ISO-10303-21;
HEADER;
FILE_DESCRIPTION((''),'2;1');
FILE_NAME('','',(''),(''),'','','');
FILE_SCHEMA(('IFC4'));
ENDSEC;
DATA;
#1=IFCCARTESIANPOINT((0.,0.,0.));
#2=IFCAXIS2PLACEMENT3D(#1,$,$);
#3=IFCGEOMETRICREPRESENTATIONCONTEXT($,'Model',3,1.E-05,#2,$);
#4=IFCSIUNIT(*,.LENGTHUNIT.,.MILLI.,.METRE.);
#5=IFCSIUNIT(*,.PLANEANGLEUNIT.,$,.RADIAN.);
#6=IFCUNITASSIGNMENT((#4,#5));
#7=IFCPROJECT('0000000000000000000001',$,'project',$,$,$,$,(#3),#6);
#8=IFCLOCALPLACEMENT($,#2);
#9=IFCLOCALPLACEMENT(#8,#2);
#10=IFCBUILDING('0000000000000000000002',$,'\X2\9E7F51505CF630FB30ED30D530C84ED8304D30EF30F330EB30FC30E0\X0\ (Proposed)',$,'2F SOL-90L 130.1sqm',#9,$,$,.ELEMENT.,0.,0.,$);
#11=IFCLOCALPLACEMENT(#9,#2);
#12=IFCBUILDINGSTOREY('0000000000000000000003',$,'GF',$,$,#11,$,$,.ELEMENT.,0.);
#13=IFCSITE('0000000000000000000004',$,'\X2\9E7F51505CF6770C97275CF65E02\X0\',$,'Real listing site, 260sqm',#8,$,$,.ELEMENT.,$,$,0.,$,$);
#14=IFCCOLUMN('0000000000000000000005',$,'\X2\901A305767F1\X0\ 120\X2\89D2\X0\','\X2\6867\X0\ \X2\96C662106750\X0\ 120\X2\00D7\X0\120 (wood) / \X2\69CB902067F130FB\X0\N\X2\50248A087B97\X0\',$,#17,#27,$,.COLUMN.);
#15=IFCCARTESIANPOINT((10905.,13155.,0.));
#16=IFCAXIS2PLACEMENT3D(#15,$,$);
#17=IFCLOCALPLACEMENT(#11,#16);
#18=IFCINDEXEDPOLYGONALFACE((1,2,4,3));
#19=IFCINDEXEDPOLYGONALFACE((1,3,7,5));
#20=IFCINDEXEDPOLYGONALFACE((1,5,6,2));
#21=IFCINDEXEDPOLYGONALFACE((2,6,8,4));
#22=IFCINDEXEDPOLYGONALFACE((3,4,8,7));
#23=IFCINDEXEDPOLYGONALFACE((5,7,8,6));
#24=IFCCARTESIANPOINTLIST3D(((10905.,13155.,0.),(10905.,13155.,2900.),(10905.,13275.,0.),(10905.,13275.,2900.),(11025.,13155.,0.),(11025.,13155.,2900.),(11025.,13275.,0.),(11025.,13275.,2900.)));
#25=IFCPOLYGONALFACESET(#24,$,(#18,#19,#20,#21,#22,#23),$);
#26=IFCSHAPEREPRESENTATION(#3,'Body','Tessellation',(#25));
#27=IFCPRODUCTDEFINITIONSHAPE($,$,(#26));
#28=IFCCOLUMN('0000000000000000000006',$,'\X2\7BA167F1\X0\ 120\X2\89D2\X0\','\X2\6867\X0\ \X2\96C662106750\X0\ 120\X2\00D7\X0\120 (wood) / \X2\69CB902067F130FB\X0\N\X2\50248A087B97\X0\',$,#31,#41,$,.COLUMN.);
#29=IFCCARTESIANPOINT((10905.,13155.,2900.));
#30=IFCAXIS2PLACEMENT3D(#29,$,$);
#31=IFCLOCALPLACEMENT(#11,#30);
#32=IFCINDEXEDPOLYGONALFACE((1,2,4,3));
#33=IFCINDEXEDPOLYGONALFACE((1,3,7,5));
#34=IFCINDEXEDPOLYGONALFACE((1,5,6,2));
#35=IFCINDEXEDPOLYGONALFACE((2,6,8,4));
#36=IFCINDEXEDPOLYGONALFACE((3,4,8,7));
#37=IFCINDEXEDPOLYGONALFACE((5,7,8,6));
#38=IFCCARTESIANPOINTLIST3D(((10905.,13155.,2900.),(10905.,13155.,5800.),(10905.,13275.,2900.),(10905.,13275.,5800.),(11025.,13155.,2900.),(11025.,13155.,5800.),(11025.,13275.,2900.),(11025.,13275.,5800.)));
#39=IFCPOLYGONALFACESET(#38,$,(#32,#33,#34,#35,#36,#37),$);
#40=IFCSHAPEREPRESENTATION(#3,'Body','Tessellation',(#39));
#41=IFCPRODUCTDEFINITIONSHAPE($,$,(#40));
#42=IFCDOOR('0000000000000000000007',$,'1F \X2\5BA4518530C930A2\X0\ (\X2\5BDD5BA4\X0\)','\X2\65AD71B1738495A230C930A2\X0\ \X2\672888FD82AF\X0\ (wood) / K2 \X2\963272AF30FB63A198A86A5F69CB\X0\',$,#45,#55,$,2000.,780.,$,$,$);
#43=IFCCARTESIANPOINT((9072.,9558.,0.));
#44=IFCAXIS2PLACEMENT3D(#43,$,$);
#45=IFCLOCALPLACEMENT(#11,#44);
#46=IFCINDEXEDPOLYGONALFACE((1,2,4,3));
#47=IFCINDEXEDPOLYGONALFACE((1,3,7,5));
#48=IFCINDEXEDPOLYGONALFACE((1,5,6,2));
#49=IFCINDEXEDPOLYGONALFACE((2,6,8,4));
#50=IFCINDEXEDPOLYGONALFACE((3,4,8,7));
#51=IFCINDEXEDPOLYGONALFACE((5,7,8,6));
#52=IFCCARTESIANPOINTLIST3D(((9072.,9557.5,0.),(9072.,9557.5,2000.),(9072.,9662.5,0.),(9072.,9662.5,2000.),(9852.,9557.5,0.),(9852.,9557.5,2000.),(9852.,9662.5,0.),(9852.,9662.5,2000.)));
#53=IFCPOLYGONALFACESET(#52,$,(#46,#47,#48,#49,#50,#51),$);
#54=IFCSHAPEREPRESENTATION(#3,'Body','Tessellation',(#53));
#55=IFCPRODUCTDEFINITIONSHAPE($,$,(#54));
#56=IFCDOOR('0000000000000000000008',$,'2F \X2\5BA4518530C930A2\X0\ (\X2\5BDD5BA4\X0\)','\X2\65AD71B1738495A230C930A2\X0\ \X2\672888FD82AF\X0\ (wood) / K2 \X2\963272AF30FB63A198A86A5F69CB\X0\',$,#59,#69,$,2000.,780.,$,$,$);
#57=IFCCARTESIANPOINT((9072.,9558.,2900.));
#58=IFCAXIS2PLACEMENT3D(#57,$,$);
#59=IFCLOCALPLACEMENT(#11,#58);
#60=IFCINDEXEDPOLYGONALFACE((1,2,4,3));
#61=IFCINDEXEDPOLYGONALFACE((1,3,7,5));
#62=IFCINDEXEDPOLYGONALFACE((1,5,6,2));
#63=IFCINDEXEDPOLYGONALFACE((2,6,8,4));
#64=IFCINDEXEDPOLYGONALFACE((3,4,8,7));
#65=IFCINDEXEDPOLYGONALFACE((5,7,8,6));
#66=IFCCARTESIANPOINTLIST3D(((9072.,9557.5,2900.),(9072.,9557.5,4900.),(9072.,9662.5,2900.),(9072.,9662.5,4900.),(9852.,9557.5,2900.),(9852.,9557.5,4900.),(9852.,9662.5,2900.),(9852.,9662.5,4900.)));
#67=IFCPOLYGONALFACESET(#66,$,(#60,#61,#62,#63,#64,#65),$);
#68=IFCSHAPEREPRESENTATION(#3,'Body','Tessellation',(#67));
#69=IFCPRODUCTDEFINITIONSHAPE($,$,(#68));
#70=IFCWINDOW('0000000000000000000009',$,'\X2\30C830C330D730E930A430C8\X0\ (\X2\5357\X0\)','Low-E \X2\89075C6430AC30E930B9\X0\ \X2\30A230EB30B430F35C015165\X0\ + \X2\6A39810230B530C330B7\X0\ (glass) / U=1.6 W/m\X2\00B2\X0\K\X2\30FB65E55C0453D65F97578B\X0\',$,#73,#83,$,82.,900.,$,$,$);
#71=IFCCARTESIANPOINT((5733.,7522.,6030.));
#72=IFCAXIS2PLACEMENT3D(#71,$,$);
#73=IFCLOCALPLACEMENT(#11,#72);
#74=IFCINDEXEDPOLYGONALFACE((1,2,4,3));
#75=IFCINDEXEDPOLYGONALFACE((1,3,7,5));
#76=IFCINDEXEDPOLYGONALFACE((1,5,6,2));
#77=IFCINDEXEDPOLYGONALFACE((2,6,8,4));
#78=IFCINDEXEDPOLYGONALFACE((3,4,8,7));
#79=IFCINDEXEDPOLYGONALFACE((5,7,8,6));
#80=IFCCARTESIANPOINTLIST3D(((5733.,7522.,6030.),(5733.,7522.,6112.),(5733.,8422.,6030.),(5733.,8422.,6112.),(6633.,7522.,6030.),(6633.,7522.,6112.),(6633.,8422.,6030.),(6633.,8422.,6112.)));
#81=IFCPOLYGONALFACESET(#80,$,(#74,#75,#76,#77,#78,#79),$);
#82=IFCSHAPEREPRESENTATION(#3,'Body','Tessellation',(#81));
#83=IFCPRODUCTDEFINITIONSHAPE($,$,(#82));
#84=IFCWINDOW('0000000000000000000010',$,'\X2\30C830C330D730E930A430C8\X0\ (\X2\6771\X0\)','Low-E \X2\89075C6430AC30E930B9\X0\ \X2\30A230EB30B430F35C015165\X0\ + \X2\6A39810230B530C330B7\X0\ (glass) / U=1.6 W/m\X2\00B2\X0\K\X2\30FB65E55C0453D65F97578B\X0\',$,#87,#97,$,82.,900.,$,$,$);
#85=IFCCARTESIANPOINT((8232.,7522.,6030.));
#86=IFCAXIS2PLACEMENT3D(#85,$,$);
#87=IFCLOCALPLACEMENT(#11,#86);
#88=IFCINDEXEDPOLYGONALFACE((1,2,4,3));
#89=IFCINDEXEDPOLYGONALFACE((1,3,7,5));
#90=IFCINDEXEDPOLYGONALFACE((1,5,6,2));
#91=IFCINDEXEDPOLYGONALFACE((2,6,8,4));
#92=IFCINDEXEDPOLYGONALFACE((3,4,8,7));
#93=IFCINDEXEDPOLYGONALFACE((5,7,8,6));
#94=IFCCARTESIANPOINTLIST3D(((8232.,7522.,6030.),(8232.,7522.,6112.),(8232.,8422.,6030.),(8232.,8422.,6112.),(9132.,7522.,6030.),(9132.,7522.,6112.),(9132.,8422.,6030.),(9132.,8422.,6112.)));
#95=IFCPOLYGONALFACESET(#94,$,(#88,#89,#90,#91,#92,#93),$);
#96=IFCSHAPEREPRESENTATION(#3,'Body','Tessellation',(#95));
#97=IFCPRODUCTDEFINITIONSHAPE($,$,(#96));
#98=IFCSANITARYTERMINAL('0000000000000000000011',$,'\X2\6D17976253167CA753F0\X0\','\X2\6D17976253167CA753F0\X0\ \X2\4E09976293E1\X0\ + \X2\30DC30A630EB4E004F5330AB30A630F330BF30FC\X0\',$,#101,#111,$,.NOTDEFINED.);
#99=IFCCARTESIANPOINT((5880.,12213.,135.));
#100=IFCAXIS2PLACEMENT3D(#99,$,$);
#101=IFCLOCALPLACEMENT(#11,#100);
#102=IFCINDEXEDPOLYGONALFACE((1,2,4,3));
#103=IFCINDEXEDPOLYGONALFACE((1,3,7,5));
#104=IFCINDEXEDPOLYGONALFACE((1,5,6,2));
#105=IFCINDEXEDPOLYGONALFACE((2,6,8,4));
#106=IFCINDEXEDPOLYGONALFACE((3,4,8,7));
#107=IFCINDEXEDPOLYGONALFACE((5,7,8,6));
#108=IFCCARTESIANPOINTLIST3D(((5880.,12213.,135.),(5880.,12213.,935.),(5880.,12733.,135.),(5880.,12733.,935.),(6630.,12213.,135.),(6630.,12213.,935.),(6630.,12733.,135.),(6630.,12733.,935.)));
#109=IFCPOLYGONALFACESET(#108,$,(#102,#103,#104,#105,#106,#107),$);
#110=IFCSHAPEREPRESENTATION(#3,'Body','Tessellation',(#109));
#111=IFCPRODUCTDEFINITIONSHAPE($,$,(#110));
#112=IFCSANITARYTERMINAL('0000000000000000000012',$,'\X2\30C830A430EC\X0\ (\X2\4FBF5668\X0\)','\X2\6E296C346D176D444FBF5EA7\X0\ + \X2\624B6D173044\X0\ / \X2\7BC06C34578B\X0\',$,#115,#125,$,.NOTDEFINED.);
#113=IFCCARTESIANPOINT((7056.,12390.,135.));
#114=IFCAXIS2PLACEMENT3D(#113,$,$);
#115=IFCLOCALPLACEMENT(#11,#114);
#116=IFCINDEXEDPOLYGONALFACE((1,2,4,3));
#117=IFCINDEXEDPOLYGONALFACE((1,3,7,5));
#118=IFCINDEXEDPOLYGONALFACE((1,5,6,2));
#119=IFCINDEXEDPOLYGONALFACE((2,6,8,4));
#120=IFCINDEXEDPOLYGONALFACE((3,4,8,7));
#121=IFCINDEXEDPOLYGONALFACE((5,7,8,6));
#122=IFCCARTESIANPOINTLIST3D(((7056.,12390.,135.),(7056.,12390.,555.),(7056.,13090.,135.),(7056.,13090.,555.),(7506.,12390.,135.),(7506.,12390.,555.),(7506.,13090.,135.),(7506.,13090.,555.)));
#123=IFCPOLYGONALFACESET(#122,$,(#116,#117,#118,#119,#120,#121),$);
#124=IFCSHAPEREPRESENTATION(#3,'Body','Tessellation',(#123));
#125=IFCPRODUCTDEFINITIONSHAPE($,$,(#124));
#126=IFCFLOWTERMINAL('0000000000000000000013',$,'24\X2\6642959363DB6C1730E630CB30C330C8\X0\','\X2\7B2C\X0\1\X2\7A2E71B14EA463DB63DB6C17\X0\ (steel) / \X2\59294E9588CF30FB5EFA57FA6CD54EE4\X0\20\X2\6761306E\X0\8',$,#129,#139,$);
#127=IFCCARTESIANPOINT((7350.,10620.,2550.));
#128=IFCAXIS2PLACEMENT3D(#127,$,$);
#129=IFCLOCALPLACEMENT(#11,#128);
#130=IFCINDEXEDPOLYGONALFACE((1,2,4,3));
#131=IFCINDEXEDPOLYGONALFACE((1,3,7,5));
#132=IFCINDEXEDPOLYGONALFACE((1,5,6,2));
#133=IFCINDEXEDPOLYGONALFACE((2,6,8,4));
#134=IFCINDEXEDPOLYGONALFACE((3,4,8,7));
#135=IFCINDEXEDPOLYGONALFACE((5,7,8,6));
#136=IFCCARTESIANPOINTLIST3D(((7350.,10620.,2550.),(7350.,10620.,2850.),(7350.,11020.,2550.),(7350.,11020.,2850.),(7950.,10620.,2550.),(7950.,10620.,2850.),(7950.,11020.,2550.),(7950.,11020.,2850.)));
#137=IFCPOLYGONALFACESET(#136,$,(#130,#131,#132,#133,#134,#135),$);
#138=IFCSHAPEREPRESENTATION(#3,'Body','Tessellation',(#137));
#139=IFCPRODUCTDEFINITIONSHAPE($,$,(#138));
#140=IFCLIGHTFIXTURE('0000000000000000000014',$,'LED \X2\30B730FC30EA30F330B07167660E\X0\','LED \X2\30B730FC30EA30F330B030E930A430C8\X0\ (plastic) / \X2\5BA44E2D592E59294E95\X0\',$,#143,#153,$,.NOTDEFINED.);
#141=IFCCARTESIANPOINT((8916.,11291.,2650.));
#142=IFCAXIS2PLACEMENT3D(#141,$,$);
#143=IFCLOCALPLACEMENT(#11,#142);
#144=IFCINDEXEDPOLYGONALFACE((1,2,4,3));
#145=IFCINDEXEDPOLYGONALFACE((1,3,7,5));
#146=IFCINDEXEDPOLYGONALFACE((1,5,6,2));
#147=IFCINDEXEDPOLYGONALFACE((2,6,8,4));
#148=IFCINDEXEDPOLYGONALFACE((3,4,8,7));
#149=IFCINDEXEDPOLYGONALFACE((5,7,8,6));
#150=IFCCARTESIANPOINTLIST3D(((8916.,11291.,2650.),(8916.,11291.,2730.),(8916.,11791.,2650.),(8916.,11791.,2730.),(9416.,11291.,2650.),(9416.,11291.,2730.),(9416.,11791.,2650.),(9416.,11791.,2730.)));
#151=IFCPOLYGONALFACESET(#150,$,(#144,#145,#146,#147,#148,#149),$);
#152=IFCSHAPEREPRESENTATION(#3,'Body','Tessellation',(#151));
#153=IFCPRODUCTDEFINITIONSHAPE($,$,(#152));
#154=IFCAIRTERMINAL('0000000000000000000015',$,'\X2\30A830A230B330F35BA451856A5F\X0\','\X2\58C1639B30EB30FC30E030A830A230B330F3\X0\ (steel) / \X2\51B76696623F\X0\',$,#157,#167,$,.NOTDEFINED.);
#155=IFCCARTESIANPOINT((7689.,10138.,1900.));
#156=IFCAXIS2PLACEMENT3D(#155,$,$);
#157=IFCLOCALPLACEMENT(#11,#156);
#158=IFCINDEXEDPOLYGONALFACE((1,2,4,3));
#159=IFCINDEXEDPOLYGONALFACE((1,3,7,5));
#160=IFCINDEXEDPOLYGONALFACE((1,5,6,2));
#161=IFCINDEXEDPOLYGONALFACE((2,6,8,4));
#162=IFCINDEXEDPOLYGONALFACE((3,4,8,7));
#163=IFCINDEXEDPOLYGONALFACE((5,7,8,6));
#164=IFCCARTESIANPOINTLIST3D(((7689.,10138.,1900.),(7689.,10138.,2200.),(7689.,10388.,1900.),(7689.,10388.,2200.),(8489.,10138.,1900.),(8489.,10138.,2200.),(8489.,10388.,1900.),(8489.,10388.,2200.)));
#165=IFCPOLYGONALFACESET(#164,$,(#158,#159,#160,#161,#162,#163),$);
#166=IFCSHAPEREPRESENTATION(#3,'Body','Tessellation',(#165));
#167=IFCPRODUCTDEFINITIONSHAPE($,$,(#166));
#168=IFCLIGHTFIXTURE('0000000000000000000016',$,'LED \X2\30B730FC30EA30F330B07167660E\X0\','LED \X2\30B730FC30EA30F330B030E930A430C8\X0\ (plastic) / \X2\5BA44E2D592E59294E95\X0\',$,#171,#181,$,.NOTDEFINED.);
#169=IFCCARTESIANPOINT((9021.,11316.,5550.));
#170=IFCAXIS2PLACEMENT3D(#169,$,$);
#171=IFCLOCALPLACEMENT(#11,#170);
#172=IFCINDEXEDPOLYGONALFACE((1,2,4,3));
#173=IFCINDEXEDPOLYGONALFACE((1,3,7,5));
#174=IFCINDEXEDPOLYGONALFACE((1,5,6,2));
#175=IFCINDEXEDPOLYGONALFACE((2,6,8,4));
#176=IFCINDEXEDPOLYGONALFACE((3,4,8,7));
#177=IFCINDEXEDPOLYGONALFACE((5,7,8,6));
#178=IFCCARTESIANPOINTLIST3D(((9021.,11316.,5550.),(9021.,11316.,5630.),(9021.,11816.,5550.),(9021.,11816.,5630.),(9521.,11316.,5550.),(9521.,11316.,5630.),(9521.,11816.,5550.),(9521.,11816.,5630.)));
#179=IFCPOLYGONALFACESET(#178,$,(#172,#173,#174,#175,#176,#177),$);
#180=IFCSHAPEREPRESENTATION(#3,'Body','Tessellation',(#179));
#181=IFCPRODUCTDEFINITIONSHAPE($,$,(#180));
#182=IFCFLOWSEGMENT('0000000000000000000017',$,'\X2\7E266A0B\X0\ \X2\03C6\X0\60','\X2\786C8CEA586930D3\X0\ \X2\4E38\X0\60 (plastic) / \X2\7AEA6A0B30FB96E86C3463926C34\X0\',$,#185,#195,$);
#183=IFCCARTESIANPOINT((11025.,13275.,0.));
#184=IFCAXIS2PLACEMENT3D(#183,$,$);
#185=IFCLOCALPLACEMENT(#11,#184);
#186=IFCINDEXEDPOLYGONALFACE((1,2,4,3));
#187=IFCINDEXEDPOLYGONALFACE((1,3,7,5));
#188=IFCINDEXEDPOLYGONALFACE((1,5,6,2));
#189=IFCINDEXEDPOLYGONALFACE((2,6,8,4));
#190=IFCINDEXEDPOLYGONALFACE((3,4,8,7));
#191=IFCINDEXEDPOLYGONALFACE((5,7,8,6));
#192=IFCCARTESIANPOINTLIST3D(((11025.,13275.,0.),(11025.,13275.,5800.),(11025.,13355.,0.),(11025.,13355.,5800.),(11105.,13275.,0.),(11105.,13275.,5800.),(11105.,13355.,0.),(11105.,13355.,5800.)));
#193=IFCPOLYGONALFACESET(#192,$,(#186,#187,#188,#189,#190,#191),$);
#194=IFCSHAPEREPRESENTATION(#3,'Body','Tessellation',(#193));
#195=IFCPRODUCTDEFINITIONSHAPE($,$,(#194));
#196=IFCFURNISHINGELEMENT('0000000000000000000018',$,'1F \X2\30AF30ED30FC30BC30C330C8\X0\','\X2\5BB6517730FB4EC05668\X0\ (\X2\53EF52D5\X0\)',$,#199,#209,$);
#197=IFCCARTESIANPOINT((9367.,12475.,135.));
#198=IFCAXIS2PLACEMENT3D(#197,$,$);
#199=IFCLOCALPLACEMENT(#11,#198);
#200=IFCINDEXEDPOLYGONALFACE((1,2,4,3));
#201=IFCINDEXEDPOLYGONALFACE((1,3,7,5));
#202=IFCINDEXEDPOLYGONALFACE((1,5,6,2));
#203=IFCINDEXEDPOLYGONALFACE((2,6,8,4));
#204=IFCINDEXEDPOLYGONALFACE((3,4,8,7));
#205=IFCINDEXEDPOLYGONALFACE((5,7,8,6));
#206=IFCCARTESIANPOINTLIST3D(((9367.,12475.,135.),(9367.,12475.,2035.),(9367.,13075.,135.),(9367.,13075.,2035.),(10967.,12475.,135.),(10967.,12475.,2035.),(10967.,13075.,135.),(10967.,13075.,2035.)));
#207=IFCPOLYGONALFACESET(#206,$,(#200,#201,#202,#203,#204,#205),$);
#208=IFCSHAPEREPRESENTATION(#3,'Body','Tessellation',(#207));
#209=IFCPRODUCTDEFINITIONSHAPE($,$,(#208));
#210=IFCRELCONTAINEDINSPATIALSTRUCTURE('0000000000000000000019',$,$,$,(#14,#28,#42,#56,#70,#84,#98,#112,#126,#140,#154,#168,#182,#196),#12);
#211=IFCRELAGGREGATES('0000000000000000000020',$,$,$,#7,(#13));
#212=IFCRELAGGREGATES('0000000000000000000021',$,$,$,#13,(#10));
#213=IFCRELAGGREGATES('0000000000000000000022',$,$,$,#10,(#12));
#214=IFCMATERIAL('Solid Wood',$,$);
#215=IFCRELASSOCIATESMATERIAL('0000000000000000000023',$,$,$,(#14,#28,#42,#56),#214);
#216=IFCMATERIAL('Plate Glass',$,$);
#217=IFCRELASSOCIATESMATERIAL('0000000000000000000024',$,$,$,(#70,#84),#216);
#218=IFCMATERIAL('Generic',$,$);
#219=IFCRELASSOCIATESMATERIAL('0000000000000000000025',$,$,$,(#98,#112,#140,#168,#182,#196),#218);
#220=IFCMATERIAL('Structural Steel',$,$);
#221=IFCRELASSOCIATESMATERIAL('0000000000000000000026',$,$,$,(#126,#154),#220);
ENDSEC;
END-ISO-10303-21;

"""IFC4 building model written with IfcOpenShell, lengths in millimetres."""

from ifc_helpers import new_model, si_unit, frame, frame_2d, origin, place, context, project, spatial, rectangle, extrude, material, element, save


model = new_model("IFC4")

# Units and contexts
model_context = context("Model", 3, precision=1e-05, world=origin())
ifc_project = project(units=[si_unit("LENGTHUNIT", "METRE", prefix="MILLI"), si_unit("PLANEANGLEUNIT", "RADIAN")], contexts=[model_context])

# Site, building, storey
site_placement = place(None, origin())
site = spatial("IfcSite", under=ifc_project, at=site_placement, Name="鹿児島県霧島市", ObjectType="Real listing site, 260sqm", CompositionType="ELEMENT", RefElevation=0.0)
building_placement = place(site_placement, origin())
building = spatial("IfcBuilding", under=site, at=building_placement, Name="鹿児島・ロフト付きワンルーム (Proposed)", ObjectType="2F SOL-90L 130.1sqm", CompositionType="ELEMENT", ElevationOfRefHeight=0.0, ElevationOfTerrain=0.0)
storey_placement = place(building_placement, origin())
storey = spatial("IfcBuildingStorey", under=building, at=storey_placement, Name="GF", CompositionType="ELEMENT", Elevation=0.0)

# Columns
ifc_material_1 = material(Name="Solid Wood")
column_1_placement = place(storey_placement, frame((10905.0, 13155.0, 0.0)))
element("IfcColumn", 1, at=column_1_placement, inside=storey, material=ifc_material_1, Name="通し柱 120角", Description="桧 集成材 120×120 (wood) / 構造柱・N値計算", PredefinedType="COLUMN", context=model_context, shape_type="SweptSolid", body=[
    extrude(rectangle(XDim=120.0, YDim=120.0, at=frame_2d((60.0, 60.0))), frame((10905.0, 13155.0, 0.0)), (0.0, 0.0, 1.0), 2900.0),
])
column_2_placement = place(storey_placement, frame((10905.0, 13155.0, 2900.0)))
element("IfcColumn", 2, at=column_2_placement, inside=storey, material=ifc_material_1, Name="管柱 120角", Description="桧 集成材 120×120 (wood) / 構造柱・N値計算", PredefinedType="COLUMN", context=model_context, shape_type="SweptSolid", body=[
    extrude(rectangle(XDim=120.0, YDim=120.0, at=frame_2d((60.0, 60.0))), frame((10905.0, 13155.0, 2900.0)), (0.0, 0.0, 1.0), 2900.0),
])

# Door
door_1_placement = place(storey_placement, frame((9072.0, 9558.0, 0.0)))
element("IfcDoor", 3, at=door_1_placement, inside=storey, material=ifc_material_1, Name="1F 室内ドア (寝室)", Description="断熱玄関ドア 木製芯 (wood) / K2 防犯・採風機構", OverallHeight=2000.0, OverallWidth=780.0, context=model_context, shape_type="SweptSolid", body=[
    extrude(rectangle(XDim=780.0, YDim=105.0, at=frame_2d((390.0, 52.0))), frame((9072.0, 9558.0, 0.0)), (0.0, 0.0, 1.0), 2000.0),
])

# Door
door_2_placement = place(storey_placement, frame((9072.0, 9558.0, 2900.0)))
element("IfcDoor", 4, at=door_2_placement, inside=storey, material=ifc_material_1, Name="2F 室内ドア (寝室)", Description="断熱玄関ドア 木製芯 (wood) / K2 防犯・採風機構", OverallHeight=2000.0, OverallWidth=780.0, context=model_context, shape_type="SweptSolid", body=[
    extrude(rectangle(XDim=780.0, YDim=105.0, at=frame_2d((390.0, 52.0))), frame((9072.0, 9558.0, 2900.0)), (0.0, 0.0, 1.0), 2000.0),
])

# Windows
ifc_material_2 = material(Name="Plate Glass")
window_1_placement = place(storey_placement, frame((5733.0, 7522.0, 6030.0)))
element("IfcWindow", 5, at=window_1_placement, inside=storey, material=ifc_material_2, Name="トップライト (南)", Description="Low-E 複層ガラス アルゴン封入 + 樹脂サッシ (glass) / U=1.6 W/m²K・日射取得型", OverallHeight=82.0, OverallWidth=900.0, context=model_context, shape_type="SweptSolid", body=[
    extrude(rectangle(XDim=900.0, YDim=900.0, at=frame_2d((450.0, 450.0))), frame((5733.0, 7522.0, 6030.0)), (0.0, 0.0, 1.0), 82.0),
])
window_2_placement = place(storey_placement, frame((8232.0, 7522.0, 6030.0)))
element("IfcWindow", 6, at=window_2_placement, inside=storey, material=ifc_material_2, Name="トップライト (東)", Description="Low-E 複層ガラス アルゴン封入 + 樹脂サッシ (glass) / U=1.6 W/m²K・日射取得型", OverallHeight=82.0, OverallWidth=900.0, context=model_context, shape_type="SweptSolid", body=[
    extrude(rectangle(XDim=900.0, YDim=900.0, at=frame_2d((450.0, 450.0))), frame((8232.0, 7522.0, 6030.0)), (0.0, 0.0, 1.0), 82.0),
])

# Sanitary terminals
ifc_material_3 = material(Name="Generic")
sanitary_terminal_1_placement = place(storey_placement, frame((5880.0, 12213.0, 135.0)))
element("IfcSanitaryTerminal", 7, at=sanitary_terminal_1_placement, inside=storey, material=ifc_material_3, Name="洗面化粧台", Description="洗面化粧台 三面鏡 + ボウル一体カウンター", PredefinedType="NOTDEFINED", context=model_context, shape_type="SweptSolid", body=[
    extrude(rectangle(XDim=750.0, YDim=520.0, at=frame_2d((375.0, 260.0))), frame((5880.0, 12213.0, 135.0)), (0.0, 0.0, 1.0), 800.0),
])
sanitary_terminal_2_placement = place(storey_placement, frame((7056.0, 12390.0, 135.0)))
element("IfcSanitaryTerminal", 8, at=sanitary_terminal_2_placement, inside=storey, material=ifc_material_3, Name="トイレ (便器)", Description="温水洗浄便座 + 手洗い / 節水型", PredefinedType="NOTDEFINED", context=model_context, shape_type="SweptSolid", body=[
    extrude(rectangle(XDim=450.0, YDim=700.0, at=frame_2d((225.0, 350.0))), frame((7056.0, 12390.0, 135.0)), (0.0, 0.0, 1.0), 420.0),
])

# Flow terminal
ifc_material_4 = material(Name="Structural Steel")
flow_terminal_placement = place(storey_placement, frame((7350.0, 10620.0, 2550.0)))
element("IfcFlowTerminal", 9, at=flow_terminal_placement, inside=storey, material=ifc_material_4, Name="24時間換気ユニット", Description="第1種熱交換換気 (steel) / 天井裏・建基法令20条の8", context=model_context, shape_type="SweptSolid", body=[
    extrude(rectangle(XDim=600.0, YDim=400.0, at=frame_2d((300.0, 200.0))), frame((7350.0, 10620.0, 2550.0)), (0.0, 0.0, 1.0), 300.0),
])

# Light fixture
light_fixture_1_placement = place(storey_placement, frame((8916.0, 11291.0, 2650.0)))
element("IfcLightFixture", 10, at=light_fixture_1_placement, inside=storey, material=ifc_material_3, Name="LED シーリング照明", Description="LED シーリングライト (plastic) / 室中央天井", PredefinedType="NOTDEFINED", context=model_context, shape_type="SweptSolid", body=[
    extrude(rectangle(XDim=500.0, YDim=500.0, at=frame_2d((250.0, 250.0))), frame((8916.0, 11291.0, 2650.0)), (0.0, 0.0, 1.0), 80.0),
])

# Air terminal
air_terminal_placement = place(storey_placement, frame((7689.0, 10138.0, 1900.0)))
element("IfcAirTerminal", 11, at=air_terminal_placement, inside=storey, material=ifc_material_4, Name="エアコン室内機", Description="壁掛ルームエアコン (steel) / 冷暖房", PredefinedType="NOTDEFINED", context=model_context, shape_type="SweptSolid", body=[
    extrude(rectangle(XDim=800.0, YDim=250.0, at=frame_2d((400.0, 125.0))), frame((7689.0, 10138.0, 1900.0)), (0.0, 0.0, 1.0), 300.0),
])

# Light fixture
light_fixture_2_placement = place(storey_placement, frame((9021.0, 11316.0, 5550.0)))
element("IfcLightFixture", 12, at=light_fixture_2_placement, inside=storey, material=ifc_material_3, Name="LED シーリング照明", Description="LED シーリングライト (plastic) / 室中央天井", PredefinedType="NOTDEFINED", context=model_context, shape_type="SweptSolid", body=[
    extrude(rectangle(XDim=500.0, YDim=500.0, at=frame_2d((250.0, 250.0))), frame((9021.0, 11316.0, 5550.0)), (0.0, 0.0, 1.0), 80.0),
])

# Flow segment
flow_segment_placement = place(storey_placement, frame((11025.0, 13275.0, 0.0)))
element("IfcFlowSegment", 13, at=flow_segment_placement, inside=storey, material=ifc_material_3, Name="縦樋 φ60", Description="硬質塩ビ 丸60 (plastic) / 竪樋・雨水排水", context=model_context, shape_type="SweptSolid", body=[
    extrude(rectangle(XDim=80.0, YDim=80.0, at=frame_2d((40.0, 40.0))), frame((11025.0, 13275.0, 0.0)), (0.0, 0.0, 1.0), 5800.0),
])

# Furnishing element
furnishing_1_placement = place(storey_placement, frame((9367.0, 12475.0, 135.0)))
element("IfcFurnishingElement", 14, at=furnishing_1_placement, inside=storey, material=ifc_material_3, Name="1F クローゼット", Description="家具・什器 (可動)", context=model_context, shape_type="SweptSolid", body=[
    extrude(rectangle(XDim=1600.0, YDim=600.0, at=frame_2d((800.0, 300.0))), frame((9367.0, 12475.0, 135.0)), (0.0, 0.0, 1.0), 1900.0),
])

save(model, "model.ifc")
